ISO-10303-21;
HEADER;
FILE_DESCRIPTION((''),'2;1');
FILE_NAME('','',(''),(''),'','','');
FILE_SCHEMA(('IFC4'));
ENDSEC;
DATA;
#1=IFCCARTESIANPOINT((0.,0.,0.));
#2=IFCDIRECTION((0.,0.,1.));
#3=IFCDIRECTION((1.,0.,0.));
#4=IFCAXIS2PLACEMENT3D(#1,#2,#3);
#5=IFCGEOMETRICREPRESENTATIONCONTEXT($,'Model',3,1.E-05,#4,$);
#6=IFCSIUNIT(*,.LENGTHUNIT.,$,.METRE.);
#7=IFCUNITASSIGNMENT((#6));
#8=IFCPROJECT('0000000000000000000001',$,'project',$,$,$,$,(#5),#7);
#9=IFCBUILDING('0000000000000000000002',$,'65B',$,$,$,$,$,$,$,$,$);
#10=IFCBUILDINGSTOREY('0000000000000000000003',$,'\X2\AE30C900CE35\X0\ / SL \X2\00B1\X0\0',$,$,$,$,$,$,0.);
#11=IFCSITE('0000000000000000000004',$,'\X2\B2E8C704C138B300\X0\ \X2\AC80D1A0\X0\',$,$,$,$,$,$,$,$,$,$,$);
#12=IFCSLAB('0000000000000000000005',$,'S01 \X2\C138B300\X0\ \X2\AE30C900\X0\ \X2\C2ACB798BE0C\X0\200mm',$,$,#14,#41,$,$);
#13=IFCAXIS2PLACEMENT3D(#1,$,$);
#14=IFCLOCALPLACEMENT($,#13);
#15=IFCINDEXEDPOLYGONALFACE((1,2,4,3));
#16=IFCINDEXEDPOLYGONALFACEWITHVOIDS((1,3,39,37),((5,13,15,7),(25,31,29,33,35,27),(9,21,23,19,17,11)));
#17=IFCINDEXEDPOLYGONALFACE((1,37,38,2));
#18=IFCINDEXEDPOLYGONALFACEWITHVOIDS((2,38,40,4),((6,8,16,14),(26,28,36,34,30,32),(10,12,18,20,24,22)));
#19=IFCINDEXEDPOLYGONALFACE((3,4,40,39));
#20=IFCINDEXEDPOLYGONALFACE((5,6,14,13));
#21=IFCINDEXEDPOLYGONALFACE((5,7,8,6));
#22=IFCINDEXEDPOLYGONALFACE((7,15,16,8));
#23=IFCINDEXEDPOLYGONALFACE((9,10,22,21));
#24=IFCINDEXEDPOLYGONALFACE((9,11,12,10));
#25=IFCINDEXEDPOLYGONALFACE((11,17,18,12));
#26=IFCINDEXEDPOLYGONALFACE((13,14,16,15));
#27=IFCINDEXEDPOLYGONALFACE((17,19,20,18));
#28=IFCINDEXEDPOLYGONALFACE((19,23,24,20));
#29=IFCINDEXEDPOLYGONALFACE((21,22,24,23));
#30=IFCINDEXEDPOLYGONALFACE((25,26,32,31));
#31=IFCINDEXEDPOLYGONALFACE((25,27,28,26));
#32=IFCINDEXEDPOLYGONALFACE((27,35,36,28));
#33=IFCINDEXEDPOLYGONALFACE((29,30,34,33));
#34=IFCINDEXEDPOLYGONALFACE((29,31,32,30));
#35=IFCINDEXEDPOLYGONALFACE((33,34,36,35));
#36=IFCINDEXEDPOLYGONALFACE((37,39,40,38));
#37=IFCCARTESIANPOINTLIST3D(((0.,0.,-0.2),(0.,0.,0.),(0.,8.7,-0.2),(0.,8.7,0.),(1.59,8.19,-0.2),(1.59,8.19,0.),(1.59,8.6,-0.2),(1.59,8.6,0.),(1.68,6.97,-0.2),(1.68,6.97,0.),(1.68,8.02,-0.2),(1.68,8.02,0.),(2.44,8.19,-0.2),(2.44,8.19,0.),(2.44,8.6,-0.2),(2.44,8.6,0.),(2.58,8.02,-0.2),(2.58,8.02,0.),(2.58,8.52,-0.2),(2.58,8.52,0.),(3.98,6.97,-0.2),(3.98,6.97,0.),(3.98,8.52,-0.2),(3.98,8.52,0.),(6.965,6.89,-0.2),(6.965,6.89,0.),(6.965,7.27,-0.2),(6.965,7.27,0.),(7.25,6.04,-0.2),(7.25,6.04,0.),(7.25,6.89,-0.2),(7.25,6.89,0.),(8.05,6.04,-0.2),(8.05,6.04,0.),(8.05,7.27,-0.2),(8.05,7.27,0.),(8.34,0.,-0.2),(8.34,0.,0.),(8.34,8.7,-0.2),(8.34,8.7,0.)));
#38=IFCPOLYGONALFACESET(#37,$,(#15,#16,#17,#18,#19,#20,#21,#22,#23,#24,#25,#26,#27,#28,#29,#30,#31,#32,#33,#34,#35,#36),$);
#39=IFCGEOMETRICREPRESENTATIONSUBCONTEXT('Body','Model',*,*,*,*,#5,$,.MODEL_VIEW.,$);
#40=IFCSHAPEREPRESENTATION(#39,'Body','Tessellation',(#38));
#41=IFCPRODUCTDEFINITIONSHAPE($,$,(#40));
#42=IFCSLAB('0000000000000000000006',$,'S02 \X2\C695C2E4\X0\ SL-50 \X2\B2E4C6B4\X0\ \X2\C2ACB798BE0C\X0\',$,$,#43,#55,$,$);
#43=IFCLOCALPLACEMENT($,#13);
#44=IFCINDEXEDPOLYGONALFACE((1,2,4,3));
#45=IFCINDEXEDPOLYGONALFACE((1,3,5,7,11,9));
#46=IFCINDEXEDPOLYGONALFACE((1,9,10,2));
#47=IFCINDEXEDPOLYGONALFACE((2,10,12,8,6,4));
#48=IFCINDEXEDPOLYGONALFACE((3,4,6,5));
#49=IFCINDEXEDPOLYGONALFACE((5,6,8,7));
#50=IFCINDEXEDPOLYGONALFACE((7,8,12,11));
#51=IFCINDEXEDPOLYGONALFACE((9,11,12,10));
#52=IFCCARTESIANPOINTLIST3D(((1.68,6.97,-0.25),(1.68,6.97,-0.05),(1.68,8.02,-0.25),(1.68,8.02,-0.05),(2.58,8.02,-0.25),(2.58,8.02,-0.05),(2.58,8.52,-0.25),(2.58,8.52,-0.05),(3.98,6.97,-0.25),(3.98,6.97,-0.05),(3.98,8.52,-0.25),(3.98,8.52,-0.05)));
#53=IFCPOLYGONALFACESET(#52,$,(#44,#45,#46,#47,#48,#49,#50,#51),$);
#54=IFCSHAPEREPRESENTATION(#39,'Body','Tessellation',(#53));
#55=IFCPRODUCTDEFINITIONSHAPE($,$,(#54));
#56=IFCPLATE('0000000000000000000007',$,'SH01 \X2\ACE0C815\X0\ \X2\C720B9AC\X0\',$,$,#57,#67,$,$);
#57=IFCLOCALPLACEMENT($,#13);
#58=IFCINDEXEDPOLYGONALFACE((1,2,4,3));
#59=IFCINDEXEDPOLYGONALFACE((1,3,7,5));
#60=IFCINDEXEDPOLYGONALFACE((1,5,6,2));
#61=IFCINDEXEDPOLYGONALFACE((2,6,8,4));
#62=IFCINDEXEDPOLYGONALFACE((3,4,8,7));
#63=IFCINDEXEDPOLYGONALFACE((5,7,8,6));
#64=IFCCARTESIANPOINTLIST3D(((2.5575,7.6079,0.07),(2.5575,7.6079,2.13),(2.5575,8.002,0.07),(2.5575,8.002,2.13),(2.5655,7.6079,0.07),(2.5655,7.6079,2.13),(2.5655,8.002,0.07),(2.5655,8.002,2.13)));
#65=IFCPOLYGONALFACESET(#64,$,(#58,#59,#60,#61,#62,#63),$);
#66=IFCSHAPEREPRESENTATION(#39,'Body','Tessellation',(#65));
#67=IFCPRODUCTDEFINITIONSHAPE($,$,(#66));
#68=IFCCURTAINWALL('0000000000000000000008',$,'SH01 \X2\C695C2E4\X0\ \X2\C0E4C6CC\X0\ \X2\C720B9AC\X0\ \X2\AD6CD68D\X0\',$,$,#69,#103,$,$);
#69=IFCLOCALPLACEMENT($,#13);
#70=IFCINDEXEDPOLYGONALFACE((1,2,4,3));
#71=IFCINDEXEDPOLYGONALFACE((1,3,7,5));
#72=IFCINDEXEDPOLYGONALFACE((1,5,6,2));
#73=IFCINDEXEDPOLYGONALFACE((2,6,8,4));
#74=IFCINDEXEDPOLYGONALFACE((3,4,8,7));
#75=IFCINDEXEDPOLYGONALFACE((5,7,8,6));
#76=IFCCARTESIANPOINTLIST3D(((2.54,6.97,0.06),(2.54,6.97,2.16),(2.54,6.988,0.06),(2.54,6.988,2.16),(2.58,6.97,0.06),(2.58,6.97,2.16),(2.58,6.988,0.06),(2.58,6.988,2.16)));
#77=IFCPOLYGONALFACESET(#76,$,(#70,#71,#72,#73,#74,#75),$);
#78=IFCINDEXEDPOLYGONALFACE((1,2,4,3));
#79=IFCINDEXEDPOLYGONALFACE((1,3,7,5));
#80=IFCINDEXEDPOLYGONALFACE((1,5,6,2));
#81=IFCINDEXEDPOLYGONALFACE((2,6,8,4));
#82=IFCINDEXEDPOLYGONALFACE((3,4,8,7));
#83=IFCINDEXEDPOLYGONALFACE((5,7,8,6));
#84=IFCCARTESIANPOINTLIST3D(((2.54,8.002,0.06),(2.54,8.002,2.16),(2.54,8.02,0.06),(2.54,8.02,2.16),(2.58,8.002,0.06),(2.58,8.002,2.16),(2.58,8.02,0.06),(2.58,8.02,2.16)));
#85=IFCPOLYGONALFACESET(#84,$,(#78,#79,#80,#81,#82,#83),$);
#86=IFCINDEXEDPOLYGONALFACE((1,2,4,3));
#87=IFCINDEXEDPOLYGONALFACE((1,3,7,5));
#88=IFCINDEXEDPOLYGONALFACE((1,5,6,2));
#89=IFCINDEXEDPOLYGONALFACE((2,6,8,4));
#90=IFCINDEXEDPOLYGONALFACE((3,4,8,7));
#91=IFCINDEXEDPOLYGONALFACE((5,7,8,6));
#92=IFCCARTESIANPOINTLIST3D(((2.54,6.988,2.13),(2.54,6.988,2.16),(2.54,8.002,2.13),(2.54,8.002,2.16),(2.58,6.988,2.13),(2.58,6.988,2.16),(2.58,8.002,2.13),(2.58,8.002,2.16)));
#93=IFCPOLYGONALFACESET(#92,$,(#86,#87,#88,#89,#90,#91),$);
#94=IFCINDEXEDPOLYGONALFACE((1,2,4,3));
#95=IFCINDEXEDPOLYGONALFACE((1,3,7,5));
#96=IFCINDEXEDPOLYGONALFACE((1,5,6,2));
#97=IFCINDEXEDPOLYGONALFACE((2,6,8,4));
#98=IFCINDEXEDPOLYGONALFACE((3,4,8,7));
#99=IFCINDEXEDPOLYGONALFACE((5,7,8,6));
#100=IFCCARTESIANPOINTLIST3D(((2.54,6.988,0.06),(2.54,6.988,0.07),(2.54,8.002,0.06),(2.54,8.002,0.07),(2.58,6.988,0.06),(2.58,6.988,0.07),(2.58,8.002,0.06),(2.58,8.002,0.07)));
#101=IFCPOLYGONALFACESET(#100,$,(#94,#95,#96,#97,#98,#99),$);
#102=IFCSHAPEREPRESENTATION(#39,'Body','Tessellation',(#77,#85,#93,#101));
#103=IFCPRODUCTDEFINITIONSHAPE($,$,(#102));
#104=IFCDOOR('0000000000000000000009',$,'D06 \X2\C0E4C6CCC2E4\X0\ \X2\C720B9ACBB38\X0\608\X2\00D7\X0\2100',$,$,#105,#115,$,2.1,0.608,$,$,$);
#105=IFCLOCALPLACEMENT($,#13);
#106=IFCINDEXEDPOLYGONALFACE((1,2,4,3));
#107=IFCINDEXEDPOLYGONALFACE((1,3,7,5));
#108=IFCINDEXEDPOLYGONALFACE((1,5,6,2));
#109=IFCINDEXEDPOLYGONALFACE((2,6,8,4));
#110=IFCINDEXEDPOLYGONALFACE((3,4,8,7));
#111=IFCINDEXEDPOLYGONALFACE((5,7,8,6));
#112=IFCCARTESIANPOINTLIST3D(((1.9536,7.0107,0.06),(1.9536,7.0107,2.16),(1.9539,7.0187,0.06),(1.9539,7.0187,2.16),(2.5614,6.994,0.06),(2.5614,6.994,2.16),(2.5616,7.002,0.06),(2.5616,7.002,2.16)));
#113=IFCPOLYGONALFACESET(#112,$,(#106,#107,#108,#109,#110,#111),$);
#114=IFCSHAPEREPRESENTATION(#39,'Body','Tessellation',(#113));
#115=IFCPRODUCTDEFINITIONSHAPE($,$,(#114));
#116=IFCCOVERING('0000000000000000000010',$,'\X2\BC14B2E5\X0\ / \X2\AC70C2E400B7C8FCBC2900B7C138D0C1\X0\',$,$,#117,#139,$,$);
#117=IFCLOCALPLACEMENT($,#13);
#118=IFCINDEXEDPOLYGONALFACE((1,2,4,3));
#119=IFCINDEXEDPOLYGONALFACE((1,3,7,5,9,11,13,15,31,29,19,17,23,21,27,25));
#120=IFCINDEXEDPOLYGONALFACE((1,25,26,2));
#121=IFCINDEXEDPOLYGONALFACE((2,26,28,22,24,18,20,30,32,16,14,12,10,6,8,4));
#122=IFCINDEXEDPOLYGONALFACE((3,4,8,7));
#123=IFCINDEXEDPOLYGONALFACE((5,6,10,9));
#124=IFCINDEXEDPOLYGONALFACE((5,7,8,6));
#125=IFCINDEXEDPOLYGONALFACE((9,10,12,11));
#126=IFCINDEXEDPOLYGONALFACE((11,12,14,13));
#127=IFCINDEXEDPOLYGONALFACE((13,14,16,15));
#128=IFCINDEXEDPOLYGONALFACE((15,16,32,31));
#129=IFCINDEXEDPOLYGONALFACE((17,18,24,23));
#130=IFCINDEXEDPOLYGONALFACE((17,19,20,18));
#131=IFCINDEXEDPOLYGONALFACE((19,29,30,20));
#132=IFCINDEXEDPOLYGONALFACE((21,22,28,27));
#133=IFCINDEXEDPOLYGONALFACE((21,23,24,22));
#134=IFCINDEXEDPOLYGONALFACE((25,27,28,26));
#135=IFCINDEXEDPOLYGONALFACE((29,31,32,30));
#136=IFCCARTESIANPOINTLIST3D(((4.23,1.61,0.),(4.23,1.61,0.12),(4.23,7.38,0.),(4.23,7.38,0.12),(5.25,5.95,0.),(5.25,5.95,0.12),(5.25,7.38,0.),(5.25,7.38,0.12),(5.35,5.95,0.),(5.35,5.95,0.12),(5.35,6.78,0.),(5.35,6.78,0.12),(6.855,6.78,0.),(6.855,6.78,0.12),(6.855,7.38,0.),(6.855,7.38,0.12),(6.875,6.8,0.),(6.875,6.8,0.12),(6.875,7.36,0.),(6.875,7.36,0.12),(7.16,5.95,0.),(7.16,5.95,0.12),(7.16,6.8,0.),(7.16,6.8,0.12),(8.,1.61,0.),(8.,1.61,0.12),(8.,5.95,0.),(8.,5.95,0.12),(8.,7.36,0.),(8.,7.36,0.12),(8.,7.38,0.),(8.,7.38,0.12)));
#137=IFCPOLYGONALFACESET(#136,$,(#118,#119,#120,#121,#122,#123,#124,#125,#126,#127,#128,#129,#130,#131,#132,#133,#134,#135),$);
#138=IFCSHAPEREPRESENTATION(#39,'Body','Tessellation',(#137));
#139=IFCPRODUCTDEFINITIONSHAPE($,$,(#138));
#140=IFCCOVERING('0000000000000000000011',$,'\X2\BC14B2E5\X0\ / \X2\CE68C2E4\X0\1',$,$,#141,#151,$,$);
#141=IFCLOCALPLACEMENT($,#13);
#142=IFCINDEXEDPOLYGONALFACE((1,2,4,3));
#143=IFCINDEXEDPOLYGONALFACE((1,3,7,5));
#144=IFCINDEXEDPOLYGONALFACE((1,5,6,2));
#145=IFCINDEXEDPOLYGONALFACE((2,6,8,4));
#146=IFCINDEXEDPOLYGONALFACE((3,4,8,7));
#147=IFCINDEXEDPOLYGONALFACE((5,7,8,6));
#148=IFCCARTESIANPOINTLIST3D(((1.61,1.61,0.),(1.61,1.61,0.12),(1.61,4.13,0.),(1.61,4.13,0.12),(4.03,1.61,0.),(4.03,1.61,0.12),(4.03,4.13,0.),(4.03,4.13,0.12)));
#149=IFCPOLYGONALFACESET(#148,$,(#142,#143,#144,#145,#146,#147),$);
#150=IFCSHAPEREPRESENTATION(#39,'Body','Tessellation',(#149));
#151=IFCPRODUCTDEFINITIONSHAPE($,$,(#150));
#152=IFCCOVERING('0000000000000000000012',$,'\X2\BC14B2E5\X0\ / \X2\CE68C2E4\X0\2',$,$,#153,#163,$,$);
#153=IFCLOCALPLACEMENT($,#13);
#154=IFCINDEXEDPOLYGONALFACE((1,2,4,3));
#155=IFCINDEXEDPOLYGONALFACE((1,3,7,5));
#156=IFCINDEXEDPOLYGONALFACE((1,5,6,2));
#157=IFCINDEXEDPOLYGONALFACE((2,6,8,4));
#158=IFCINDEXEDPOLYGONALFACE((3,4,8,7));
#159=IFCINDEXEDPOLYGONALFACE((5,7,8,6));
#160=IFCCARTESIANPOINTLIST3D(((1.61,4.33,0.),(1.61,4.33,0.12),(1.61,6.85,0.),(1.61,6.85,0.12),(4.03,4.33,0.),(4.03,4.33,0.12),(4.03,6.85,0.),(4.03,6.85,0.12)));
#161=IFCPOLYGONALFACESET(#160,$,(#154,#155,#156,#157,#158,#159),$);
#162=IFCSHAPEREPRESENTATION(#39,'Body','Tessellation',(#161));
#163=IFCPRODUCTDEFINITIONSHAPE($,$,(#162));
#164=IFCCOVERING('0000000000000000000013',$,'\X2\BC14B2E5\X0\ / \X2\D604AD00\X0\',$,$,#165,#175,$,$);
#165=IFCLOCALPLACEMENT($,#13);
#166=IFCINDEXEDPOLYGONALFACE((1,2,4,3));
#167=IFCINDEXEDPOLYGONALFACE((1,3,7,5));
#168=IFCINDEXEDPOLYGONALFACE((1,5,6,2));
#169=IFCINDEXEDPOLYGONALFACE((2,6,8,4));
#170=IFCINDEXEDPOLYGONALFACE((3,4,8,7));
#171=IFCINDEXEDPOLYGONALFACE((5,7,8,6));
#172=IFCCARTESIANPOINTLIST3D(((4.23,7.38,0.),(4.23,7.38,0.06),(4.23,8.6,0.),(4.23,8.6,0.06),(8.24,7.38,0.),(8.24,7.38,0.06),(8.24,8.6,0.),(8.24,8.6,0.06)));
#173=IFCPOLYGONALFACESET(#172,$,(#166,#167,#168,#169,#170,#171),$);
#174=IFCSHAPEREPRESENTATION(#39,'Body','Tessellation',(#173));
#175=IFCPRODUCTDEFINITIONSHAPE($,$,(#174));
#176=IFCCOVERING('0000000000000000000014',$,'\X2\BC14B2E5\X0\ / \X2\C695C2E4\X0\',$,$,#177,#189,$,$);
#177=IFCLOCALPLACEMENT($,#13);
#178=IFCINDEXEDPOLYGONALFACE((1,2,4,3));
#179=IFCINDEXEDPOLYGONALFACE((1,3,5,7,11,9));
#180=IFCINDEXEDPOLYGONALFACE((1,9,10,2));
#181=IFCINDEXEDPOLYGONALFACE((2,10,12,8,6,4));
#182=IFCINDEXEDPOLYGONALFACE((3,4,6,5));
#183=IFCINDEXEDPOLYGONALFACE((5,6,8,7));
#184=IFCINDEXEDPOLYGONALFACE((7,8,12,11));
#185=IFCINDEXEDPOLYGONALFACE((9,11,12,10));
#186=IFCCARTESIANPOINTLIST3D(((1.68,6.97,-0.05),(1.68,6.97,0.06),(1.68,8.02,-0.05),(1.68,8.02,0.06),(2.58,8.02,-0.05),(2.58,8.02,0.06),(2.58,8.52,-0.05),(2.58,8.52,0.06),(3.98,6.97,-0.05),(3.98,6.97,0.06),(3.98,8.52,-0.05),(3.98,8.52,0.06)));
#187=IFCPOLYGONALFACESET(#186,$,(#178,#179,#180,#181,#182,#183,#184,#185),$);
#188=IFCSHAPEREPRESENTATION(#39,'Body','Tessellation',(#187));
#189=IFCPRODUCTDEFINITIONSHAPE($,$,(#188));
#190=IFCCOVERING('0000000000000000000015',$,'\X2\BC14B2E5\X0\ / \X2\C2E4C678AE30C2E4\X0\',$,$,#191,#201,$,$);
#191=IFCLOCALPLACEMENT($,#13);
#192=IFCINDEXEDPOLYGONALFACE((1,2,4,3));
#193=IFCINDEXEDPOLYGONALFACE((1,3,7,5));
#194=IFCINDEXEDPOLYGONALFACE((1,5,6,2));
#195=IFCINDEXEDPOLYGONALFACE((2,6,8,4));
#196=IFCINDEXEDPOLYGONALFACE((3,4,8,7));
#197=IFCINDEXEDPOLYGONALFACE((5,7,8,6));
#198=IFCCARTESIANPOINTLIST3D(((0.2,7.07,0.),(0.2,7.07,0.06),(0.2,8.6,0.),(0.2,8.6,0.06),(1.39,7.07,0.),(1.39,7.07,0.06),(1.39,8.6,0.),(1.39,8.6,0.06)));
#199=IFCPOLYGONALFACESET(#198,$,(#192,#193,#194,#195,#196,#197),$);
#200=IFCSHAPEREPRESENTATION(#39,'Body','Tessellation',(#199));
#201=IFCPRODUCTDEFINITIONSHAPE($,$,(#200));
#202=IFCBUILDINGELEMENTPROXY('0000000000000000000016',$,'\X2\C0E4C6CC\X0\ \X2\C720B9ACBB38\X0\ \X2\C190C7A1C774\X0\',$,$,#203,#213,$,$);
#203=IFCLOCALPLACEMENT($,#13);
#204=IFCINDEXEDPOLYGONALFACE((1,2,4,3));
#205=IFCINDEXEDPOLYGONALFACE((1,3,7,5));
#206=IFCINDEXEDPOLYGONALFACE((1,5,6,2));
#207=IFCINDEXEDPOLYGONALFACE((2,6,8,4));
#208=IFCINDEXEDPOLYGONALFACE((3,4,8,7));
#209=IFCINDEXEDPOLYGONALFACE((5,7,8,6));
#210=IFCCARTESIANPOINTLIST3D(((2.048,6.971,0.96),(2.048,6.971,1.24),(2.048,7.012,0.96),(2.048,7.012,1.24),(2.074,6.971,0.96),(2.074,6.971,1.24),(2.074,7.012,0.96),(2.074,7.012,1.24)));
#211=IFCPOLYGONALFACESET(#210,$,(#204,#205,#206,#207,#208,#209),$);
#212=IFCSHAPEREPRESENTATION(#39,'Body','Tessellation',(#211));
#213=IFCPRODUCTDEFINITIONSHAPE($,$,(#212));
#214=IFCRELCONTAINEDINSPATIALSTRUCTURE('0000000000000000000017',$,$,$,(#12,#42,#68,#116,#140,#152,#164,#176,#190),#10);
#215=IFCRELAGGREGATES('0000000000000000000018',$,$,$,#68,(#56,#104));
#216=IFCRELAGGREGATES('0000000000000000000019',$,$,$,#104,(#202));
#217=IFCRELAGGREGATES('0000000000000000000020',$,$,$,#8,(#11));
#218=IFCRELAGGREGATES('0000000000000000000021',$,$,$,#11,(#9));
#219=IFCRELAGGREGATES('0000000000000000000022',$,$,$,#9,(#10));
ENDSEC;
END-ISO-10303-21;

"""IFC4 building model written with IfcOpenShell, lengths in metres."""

from ifc_helpers import new_model, si_unit, frame, origin, origin_with_axes, place, context, subcontext, project, spatial, polyline, outline, extrude, element, aggregate, save


model = new_model("IFC4")

# Units and contexts
model_context = context("Model", 3, precision=1e-05, world=origin_with_axes())
body_context = subcontext(model_context, "Body", "Model", "MODEL_VIEW")
ifc_project = project(units=[si_unit("LENGTHUNIT", "METRE")], contexts=[model_context])

# Site, building, storey
site = spatial("IfcSite", under=ifc_project, Name="단위세대 검토")
building = spatial("IfcBuilding", under=site, Name="65B")
storey = spatial("IfcBuildingStorey", under=building, Name="기준층 / SL ±0", Elevation=0.0)

# Slabs
slab_1_placement = place(None, origin_with_axes())
element("IfcSlab", 1, at=slab_1_placement, inside=storey, Name="S01 세대 기준 슬래브200mm", context=body_context, shape_type="SweptSolid", body=[
    extrude(outline(polyline([(0.0, 0.0), (0.0, 8.7), (8.34, 8.7), (8.34, 0.0), (0.0, 0.0)]), holes=[polyline([(8.05, 7.27), (6.965, 7.27), (6.965, 6.89), (7.25, 6.89), (7.25, 6.04), (8.05, 6.04), (8.05, 7.27)]), polyline([(1.68, 8.02), (1.68, 6.97), (3.98, 6.97), (3.98, 8.52), (2.58, 8.52), (2.58, 8.02), (1.68, 8.02)]), polyline([(2.44, 8.19), (2.44, 8.6), (1.59, 8.6), (1.59, 8.19), (2.44, 8.19)])]), frame((0.0, 0.0, -0.2)), (0.0, 0.0, 1.0), 0.2),
])
slab_2_placement = place(None, origin_with_axes())
element("IfcSlab", 2, at=slab_2_placement, inside=storey, Name="S02 욕실 SL-50 다운 슬래브", context=body_context, shape_type="SweptSolid", body=[
    extrude(outline(polyline([(1.68, 6.97), (3.98, 6.97), (3.98, 8.52), (2.58, 8.52), (2.58, 8.02), (1.68, 8.02), (1.68, 6.97)])), frame((0.0, 0.0, -0.25)), (0.0, 0.0, 1.0), 0.2),
])

# Plate
curtain_wall_placement = place(None, origin_with_axes())
plate_placement = place(curtain_wall_placement, origin_with_axes())
plate = element("IfcPlate", 3, at=plate_placement, Name="SH01 고정 유리", context=body_context, shape_type="SweptSolid", body=[
    extrude(outline(polyline([(2.5655, 7.6079), (2.5655, 8.002), (2.5575, 8.002), (2.5575, 7.6079), (2.5655, 7.6079)])), frame((0.0, 0.0, 0.07)), (0.0, 0.0, 1.0), 2.06),
])

# Curtain wall, door
curtain_wall = element("IfcCurtainWall", 4, at=curtain_wall_placement, inside=storey, Name="SH01 욕실 샤워 유리 구획", context=body_context, shape_type="SweptSolid", body=[
    extrude(outline(polyline([(2.58, 6.97), (2.58, 6.988), (2.54, 6.988), (2.54, 6.97), (2.58, 6.97)])), frame((0.0, 0.0, 0.06)), (0.0, 0.0, 1.0), 2.1),
    extrude(outline(polyline([(2.58, 8.002), (2.58, 8.02), (2.54, 8.02), (2.54, 8.002), (2.58, 8.002)])), frame((0.0, 0.0, 0.06)), (0.0, 0.0, 1.0), 2.1),
    extrude(outline(polyline([(2.58, 6.988), (2.58, 8.002), (2.54, 8.002), (2.54, 6.988), (2.58, 6.988)])), frame((0.0, 0.0, 2.13)), (0.0, 0.0, 1.0), 0.03),
    extrude(outline(polyline([(2.58, 6.988), (2.58, 8.002), (2.54, 8.002), (2.54, 6.988), (2.58, 6.988)])), frame((0.0, 0.0, 0.06)), (0.0, 0.0, 1.0), 0.01),
])
door_placement = place(curtain_wall_placement, origin_with_axes())
door = element("IfcDoor", 5, at=door_placement, Name="D06 샤워실 유리문608×2100", OverallHeight=2.1, OverallWidth=0.608, context=body_context, shape_type="SweptSolid", body=[
    extrude(outline(polyline([(2.5614, 6.994), (1.9536, 7.0107), (1.9539, 7.0187), (2.5616, 7.002), (2.5614, 6.994)])), frame((0.0, 0.0, 0.06)), (0.0, 0.0, 1.0), 2.1),
])
aggregate(curtain_wall, [plate, door])

# Coverings
covering_1_placement = place(None, origin_with_axes())
element("IfcCovering", 6, at=covering_1_placement, inside=storey, Name="바닥 / 거실·주방·세탁", context=body_context, shape_type="SweptSolid", body=[
    extrude(outline(polyline([(8.0, 1.61), (4.23, 1.61), (4.23, 7.38), (5.25, 7.38), (5.25, 5.95), (5.35, 5.95), (5.35, 6.78), (6.855, 6.78), (6.855, 7.38), (8.0, 7.38), (8.0, 7.36), (6.875, 7.36), (6.875, 6.8), (7.16, 6.8), (7.16, 5.95), (8.0, 5.95), (8.0, 1.61)])), origin(), (0.0, 0.0, 1.0), 0.12),
])
covering_2_placement = place(None, origin_with_axes())
element("IfcCovering", 7, at=covering_2_placement, inside=storey, Name="바닥 / 침실1", context=body_context, shape_type="SweptSolid", body=[
    extrude(outline(polyline([(4.03, 1.61), (4.03, 4.13), (1.61, 4.13), (1.61, 1.61), (4.03, 1.61)])), origin(), (0.0, 0.0, 1.0), 0.12),
])
covering_3_placement = place(None, origin_with_axes())
element("IfcCovering", 8, at=covering_3_placement, inside=storey, Name="바닥 / 침실2", context=body_context, shape_type="SweptSolid", body=[
    extrude(outline(polyline([(4.03, 4.33), (4.03, 6.85), (1.61, 6.85), (1.61, 4.33), (4.03, 4.33)])), origin(), (0.0, 0.0, 1.0), 0.12),
])
covering_4_placement = place(None, origin_with_axes())
element("IfcCovering", 9, at=covering_4_placement, inside=storey, Name="바닥 / 현관", context=body_context, shape_type="SweptSolid", body=[
    extrude(outline(polyline([(8.24, 7.38), (8.24, 8.6), (4.23, 8.6), (4.23, 7.38), (8.24, 7.38)])), origin(), (0.0, 0.0, 1.0), 0.06),
])
covering_5_placement = place(None, origin_with_axes())
element("IfcCovering", 10, at=covering_5_placement, inside=storey, Name="바닥 / 욕실", context=body_context, shape_type="SweptSolid", body=[
    extrude(outline(polyline([(1.68, 6.97), (3.98, 6.97), (3.98, 8.52), (2.58, 8.52), (2.58, 8.02), (1.68, 8.02), (1.68, 6.97)])), frame((0.0, 0.0, -0.05)), (0.0, 0.0, 1.0), 0.11),
])
covering_6_placement = place(None, origin_with_axes())
element("IfcCovering", 11, at=covering_6_placement, inside=storey, Name="바닥 / 실외기실", context=body_context, shape_type="SweptSolid", body=[
    extrude(outline(polyline([(1.39, 7.07), (1.39, 8.6), (0.2, 8.6), (0.2, 7.07), (1.39, 7.07)])), origin(), (0.0, 0.0, 1.0), 0.06),
])

# Building element proxy
proxy_1_placement = place(door_placement, origin_with_axes())
proxy_1 = element("IfcBuildingElementProxy", 12, at=proxy_1_placement, Name="샤워 유리문 손잡이", context=body_context, shape_type="SweptSolid", body=[
    extrude(outline(polyline([(2.074, 6.971), (2.074, 7.012), (2.048, 7.012), (2.048, 6.971), (2.074, 6.971)])), frame((0.0, 0.0, 0.96)), (0.0, 0.0, 1.0), 0.28),
])
aggregate(door, [proxy_1])

save(model, "model.ifc")
